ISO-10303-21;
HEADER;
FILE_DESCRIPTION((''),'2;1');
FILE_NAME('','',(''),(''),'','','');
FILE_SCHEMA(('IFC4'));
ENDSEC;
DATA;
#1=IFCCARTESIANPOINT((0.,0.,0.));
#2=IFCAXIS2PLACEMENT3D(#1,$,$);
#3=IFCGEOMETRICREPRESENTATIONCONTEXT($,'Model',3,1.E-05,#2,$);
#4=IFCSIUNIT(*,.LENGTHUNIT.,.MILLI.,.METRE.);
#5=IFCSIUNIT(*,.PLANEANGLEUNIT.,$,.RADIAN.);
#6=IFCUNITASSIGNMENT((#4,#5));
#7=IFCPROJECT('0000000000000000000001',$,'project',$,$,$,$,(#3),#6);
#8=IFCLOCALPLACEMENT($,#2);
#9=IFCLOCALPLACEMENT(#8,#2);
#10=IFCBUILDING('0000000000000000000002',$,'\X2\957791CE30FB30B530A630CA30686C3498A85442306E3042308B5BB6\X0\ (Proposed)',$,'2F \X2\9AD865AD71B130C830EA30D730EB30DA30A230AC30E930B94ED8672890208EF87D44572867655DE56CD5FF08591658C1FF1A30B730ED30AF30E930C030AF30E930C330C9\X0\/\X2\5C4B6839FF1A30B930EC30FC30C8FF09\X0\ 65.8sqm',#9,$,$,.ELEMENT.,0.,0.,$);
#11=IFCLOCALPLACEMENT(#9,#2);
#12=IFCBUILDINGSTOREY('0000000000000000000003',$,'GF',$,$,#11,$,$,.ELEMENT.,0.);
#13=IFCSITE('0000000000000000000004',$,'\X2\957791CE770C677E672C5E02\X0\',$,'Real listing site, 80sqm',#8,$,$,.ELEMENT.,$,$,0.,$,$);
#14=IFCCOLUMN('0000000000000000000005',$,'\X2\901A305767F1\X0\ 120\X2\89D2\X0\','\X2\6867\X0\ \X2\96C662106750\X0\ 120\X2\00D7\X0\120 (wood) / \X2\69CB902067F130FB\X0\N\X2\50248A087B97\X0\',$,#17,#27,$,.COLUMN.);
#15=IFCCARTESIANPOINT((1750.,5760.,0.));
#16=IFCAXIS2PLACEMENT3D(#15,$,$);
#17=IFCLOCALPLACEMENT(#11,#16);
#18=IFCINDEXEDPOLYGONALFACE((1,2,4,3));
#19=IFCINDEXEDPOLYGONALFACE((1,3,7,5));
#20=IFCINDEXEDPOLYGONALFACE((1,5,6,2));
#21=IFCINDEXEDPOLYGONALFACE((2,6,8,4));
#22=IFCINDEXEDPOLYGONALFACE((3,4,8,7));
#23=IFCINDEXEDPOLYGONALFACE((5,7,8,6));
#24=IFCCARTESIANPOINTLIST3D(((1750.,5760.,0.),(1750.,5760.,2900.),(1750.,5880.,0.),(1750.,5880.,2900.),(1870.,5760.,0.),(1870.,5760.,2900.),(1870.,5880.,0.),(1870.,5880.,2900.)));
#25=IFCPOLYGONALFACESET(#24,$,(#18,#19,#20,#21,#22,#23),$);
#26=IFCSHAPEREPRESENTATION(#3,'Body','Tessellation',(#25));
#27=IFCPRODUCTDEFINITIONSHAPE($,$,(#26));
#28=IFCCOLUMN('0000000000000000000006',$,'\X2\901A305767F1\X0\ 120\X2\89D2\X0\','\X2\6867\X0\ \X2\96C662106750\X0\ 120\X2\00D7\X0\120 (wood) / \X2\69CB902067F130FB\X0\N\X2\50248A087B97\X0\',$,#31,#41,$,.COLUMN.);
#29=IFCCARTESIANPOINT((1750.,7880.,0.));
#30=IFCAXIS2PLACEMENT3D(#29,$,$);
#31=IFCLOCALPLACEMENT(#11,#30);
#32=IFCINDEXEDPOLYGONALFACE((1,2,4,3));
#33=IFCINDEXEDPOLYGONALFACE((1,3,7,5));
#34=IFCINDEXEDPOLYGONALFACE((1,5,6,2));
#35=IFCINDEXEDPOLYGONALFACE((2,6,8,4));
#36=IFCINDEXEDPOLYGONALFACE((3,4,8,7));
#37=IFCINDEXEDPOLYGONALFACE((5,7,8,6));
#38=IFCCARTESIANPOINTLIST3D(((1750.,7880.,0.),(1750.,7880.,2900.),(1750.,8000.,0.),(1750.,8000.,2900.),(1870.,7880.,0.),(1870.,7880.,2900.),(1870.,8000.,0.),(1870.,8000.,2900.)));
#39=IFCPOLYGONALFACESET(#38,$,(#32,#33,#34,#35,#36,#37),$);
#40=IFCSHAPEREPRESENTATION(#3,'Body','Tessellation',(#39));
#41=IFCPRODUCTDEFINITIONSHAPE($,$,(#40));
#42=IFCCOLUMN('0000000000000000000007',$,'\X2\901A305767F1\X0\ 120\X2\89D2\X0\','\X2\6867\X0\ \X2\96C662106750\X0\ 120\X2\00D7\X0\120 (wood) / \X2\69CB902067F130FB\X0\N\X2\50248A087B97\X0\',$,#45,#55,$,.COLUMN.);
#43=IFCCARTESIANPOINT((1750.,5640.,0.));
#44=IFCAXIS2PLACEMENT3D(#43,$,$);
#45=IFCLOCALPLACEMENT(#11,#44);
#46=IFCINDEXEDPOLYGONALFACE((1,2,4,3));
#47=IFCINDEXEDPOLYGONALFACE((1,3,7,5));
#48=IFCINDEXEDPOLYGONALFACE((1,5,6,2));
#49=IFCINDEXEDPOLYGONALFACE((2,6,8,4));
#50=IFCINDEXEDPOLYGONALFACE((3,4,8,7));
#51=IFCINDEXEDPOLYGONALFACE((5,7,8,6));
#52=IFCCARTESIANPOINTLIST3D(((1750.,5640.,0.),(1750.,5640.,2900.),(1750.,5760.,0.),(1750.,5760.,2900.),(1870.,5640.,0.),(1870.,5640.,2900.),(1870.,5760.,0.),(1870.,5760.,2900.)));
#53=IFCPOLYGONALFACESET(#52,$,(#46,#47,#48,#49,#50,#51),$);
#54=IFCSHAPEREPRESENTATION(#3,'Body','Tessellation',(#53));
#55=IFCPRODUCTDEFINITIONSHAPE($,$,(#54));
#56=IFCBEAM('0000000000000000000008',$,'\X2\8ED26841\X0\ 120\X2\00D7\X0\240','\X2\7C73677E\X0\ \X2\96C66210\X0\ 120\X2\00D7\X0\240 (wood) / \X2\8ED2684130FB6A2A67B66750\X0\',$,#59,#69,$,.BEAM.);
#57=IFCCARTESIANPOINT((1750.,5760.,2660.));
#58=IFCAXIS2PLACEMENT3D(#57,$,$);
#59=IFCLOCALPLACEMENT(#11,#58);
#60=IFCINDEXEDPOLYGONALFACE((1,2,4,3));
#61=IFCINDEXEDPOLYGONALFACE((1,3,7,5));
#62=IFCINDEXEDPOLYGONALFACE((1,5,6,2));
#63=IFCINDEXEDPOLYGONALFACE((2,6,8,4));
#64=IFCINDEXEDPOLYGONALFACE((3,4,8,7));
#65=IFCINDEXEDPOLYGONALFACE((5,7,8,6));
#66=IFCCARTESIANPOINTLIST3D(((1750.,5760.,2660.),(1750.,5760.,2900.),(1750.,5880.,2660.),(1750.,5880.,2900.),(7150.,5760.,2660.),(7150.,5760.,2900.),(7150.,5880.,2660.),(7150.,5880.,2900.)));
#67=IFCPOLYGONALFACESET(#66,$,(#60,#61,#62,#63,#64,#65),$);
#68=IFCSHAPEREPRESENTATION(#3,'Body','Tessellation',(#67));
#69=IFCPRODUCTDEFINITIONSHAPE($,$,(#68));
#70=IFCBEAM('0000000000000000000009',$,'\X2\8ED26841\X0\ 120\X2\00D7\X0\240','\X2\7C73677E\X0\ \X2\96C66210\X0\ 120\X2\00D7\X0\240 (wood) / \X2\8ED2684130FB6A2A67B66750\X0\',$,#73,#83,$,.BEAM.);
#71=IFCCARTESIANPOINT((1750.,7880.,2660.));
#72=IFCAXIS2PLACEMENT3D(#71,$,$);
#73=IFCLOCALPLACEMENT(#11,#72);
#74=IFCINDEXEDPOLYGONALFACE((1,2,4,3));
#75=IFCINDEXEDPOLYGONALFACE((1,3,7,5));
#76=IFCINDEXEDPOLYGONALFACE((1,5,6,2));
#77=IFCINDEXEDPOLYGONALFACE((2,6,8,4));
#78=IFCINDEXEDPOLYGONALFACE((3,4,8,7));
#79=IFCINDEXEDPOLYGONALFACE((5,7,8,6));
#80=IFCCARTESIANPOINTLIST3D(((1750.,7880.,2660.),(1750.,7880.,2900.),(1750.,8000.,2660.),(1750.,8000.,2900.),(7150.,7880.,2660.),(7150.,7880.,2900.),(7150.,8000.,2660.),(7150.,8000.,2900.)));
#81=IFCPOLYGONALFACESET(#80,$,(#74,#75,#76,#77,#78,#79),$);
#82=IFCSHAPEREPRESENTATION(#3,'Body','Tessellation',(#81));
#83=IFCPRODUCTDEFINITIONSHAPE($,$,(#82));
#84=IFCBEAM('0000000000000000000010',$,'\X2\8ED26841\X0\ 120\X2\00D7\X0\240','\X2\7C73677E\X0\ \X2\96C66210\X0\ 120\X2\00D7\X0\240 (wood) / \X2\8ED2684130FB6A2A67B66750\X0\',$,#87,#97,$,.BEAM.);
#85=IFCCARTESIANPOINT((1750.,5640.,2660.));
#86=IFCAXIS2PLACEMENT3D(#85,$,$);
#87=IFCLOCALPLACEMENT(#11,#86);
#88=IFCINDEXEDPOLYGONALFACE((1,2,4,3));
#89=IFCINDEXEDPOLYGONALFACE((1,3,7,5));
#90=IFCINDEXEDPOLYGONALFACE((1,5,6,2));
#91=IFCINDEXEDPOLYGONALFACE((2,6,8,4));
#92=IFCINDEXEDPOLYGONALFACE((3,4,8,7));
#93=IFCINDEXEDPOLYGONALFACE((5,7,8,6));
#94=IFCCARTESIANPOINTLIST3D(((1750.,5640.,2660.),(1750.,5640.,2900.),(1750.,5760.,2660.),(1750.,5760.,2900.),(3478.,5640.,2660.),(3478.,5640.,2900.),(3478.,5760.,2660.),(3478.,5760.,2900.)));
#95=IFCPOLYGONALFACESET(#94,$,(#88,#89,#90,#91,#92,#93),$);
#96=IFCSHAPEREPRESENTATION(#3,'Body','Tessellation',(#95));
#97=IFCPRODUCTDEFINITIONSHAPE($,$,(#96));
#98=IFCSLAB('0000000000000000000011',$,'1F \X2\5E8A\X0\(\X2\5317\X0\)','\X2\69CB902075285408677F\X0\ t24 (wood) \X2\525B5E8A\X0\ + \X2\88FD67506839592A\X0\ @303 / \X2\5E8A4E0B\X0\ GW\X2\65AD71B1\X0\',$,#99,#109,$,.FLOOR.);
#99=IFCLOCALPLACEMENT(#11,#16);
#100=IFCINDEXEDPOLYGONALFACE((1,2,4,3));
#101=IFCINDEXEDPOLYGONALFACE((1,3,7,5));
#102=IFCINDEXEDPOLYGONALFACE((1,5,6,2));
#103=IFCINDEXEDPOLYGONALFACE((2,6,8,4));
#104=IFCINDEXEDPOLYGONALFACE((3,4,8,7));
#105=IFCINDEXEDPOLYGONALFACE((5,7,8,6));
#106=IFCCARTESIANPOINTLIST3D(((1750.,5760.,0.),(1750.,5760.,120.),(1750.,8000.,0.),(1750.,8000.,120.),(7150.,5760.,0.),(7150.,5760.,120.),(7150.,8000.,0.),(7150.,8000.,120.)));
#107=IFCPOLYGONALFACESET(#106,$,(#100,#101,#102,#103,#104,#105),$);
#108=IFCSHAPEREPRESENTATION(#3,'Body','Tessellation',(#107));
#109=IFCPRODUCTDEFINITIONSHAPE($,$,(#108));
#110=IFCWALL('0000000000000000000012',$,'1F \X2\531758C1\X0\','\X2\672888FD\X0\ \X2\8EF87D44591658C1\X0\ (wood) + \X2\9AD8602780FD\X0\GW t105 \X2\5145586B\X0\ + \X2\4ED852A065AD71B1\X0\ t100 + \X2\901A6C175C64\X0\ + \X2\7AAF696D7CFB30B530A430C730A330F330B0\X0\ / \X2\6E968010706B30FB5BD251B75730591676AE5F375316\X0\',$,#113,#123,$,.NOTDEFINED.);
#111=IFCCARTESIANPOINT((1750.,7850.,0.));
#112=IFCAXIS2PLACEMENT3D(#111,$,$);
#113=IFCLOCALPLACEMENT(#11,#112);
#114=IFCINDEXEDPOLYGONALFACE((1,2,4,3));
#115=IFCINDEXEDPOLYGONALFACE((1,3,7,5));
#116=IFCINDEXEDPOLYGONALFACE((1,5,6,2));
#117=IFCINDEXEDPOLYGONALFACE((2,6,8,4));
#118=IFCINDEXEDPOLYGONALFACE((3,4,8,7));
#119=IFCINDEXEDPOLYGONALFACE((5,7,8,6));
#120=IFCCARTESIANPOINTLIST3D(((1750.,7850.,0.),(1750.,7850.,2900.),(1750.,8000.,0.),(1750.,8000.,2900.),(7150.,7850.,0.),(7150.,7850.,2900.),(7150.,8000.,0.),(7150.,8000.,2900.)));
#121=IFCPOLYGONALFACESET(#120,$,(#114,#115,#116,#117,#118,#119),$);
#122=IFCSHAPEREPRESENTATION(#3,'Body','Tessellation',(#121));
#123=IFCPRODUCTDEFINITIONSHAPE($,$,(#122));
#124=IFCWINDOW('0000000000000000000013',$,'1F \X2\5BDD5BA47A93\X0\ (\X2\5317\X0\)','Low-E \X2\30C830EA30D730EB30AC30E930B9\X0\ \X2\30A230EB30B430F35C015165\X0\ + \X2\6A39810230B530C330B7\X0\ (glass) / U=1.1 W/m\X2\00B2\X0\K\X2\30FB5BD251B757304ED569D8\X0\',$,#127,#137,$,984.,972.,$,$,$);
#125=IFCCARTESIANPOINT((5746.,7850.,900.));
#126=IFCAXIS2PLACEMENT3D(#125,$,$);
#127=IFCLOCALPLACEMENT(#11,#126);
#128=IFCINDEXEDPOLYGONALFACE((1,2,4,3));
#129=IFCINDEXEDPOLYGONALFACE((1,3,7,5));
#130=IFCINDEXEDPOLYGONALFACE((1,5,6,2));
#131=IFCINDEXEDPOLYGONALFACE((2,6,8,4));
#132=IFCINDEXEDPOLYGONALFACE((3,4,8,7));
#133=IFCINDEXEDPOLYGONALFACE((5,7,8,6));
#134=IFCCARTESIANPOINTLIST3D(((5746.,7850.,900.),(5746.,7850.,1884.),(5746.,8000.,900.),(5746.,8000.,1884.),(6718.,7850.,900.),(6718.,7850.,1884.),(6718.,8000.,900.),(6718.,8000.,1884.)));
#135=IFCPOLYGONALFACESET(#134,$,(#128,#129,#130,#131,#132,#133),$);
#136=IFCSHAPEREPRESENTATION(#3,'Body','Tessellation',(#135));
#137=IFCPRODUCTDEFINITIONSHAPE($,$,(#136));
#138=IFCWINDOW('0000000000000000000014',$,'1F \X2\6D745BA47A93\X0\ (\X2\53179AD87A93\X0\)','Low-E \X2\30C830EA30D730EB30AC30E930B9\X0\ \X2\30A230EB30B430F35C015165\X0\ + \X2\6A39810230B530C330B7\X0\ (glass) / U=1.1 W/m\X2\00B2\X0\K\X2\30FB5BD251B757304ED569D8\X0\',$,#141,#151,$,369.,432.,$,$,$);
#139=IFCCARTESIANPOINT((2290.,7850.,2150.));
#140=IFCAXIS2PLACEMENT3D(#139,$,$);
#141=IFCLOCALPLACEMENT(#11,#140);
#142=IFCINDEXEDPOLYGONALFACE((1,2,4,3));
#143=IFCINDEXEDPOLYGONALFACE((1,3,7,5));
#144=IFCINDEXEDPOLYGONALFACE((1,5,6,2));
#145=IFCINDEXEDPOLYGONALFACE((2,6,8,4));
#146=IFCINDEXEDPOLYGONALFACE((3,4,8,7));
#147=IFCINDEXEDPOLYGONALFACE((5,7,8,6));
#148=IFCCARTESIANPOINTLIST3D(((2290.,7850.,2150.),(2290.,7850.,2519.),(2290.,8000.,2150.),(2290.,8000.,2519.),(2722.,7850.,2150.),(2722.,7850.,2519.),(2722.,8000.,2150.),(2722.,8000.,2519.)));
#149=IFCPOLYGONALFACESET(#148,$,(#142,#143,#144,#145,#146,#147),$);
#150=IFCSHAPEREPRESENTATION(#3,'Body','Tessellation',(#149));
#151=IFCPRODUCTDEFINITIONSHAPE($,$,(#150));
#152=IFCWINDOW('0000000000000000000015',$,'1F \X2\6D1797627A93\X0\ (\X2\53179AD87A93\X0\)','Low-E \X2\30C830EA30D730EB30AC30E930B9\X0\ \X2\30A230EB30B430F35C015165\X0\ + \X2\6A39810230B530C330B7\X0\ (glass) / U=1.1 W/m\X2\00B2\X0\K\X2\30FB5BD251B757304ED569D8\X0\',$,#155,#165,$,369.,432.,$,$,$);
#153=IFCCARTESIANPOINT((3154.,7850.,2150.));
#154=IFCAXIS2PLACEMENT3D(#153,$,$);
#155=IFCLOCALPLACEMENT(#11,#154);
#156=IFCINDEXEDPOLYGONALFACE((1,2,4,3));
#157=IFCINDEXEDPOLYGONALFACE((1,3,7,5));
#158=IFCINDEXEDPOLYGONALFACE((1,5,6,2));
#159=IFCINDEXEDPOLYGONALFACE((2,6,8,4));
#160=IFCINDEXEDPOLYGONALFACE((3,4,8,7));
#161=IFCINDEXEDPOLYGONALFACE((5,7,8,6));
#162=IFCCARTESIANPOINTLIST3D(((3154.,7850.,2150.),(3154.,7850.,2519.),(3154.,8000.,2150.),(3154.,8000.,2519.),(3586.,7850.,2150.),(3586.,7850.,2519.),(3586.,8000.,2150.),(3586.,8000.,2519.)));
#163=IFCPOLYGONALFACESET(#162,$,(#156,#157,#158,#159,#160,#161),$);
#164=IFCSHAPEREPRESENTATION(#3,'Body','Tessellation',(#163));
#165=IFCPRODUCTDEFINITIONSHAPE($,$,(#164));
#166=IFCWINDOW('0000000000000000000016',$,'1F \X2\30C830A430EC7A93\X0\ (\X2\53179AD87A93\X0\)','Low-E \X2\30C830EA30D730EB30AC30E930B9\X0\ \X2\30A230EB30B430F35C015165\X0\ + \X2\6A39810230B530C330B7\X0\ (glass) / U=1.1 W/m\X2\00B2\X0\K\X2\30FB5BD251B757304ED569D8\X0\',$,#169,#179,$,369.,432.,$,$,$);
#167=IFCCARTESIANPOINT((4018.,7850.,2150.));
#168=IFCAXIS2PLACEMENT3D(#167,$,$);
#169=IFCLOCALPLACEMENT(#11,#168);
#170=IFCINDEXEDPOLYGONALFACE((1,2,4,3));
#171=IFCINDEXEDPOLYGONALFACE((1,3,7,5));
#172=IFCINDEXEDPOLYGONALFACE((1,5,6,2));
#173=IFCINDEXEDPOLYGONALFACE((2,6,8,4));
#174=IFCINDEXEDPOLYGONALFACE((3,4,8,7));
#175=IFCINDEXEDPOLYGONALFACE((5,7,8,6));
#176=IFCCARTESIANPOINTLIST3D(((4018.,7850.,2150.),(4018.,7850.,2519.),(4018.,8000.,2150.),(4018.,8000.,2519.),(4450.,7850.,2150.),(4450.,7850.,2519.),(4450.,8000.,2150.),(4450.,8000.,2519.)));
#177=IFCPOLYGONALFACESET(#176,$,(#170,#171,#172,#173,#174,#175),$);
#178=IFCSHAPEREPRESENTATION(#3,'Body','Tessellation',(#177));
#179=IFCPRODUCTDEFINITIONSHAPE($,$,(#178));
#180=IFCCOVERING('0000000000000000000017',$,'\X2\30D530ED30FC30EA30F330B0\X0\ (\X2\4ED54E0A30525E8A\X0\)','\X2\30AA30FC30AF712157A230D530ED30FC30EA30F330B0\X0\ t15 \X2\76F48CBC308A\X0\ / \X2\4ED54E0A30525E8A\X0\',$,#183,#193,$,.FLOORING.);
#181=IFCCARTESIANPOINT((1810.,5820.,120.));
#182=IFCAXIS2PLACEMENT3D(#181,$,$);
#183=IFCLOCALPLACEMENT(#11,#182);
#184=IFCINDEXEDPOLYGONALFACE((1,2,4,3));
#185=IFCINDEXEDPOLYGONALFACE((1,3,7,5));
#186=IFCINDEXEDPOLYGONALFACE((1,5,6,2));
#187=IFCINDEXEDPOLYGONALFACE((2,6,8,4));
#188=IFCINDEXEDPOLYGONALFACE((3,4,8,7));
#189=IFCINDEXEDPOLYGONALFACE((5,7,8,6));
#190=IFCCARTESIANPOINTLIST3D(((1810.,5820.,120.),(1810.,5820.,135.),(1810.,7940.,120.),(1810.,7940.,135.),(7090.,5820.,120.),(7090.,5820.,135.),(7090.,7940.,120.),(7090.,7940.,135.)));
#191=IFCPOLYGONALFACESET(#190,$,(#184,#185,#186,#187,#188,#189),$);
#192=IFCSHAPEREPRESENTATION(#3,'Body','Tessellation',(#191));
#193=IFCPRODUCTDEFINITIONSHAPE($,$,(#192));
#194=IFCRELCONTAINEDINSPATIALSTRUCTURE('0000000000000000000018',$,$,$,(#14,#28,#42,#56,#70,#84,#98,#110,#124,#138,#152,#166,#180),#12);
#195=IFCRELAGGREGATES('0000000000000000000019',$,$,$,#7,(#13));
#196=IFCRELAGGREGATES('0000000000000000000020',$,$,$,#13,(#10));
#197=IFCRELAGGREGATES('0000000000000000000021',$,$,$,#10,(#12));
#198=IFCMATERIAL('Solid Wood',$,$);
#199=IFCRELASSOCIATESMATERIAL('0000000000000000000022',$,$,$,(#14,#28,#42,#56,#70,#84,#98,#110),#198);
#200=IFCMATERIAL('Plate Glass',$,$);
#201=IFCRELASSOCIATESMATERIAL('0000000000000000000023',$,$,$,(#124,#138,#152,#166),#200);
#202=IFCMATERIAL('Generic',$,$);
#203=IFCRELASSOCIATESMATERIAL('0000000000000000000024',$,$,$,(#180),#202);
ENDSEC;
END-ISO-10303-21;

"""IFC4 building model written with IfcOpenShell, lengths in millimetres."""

from ifc_helpers import new_model, si_unit, frame, frame_2d, origin, place, context, project, spatial, rectangle, extrude, material, element, fill, save


model = new_model("IFC4")

# Units and contexts
model_context = context("Model", 3, precision=1e-05, world=origin())
ifc_project = project(units=[si_unit("LENGTHUNIT", "METRE", prefix="MILLI"), si_unit("PLANEANGLEUNIT", "RADIAN")], contexts=[model_context])

# Site, building, storey
site_placement = place(None, origin())
site = spatial("IfcSite", under=ifc_project, at=site_placement, Name="長野県松本市", ObjectType="Real listing site, 80sqm", CompositionType="ELEMENT", RefElevation=0.0)
building_placement = place(site_placement, origin())
building = spatial("IfcBuilding", under=site, at=building_placement, Name="長野・サウナと水風呂のある家 (Proposed)", ObjectType="2F 高断熱トリプルペアガラス付木造軸組在来工法（外壁：シロクラダクラッド/屋根：スレート） 65.8sqm", CompositionType="ELEMENT", ElevationOfRefHeight=0.0, ElevationOfTerrain=0.0)
storey_placement = place(building_placement, origin())
storey = spatial("IfcBuildingStorey", under=building, at=storey_placement, Name="GF", CompositionType="ELEMENT", Elevation=0.0)

# Columns
ifc_material_1 = material(Name="Solid Wood")
column_1_placement = place(storey_placement, frame((1750.0, 5760.0, 0.0)))
element("IfcColumn", 1, at=column_1_placement, inside=storey, material=ifc_material_1, Name="通し柱 120角", Description="桧 集成材 120×120 (wood) / 構造柱・N値計算", PredefinedType="COLUMN", context=model_context, shape_type="SweptSolid", body=[
    extrude(rectangle(XDim=120.0, YDim=120.0, at=frame_2d((60.0, 60.0))), frame((1750.0, 5760.0, 0.0)), (0.0, 0.0, 1.0), 2900.0),
])
column_2_placement = place(storey_placement, frame((1750.0, 7880.0, 0.0)))
element("IfcColumn", 2, at=column_2_placement, inside=storey, material=ifc_material_1, Name="通し柱 120角", Description="桧 集成材 120×120 (wood) / 構造柱・N値計算", PredefinedType="COLUMN", context=model_context, shape_type="SweptSolid", body=[
    extrude(rectangle(XDim=120.0, YDim=120.0, at=frame_2d((60.0, 60.0))), frame((1750.0, 7880.0, 0.0)), (0.0, 0.0, 1.0), 2900.0),
])
column_3_placement = place(storey_placement, frame((1750.0, 5640.0, 0.0)))
element("IfcColumn", 3, at=column_3_placement, inside=storey, material=ifc_material_1, Name="通し柱 120角", Description="桧 集成材 120×120 (wood) / 構造柱・N値計算", PredefinedType="COLUMN", context=model_context, shape_type="SweptSolid", body=[
    extrude(rectangle(XDim=120.0, YDim=120.0, at=frame_2d((60.0, 60.0))), frame((1750.0, 5640.0, 0.0)), (0.0, 0.0, 1.0), 2900.0),
])

# Beams
beam_1_placement = place(storey_placement, frame((1750.0, 5760.0, 2660.0)))
element("IfcBeam", 4, at=beam_1_placement, inside=storey, material=ifc_material_1, Name="軒桁 120×240", Description="米松 集成 120×240 (wood) / 軒桁・横架材", PredefinedType="BEAM", context=model_context, shape_type="SweptSolid", body=[
    extrude(rectangle(XDim=5400.0, YDim=120.0, at=frame_2d((2700.0, 60.0))), frame((1750.0, 5760.0, 2660.0)), (0.0, 0.0, 1.0), 240.0),
])
beam_2_placement = place(storey_placement, frame((1750.0, 7880.0, 2660.0)))
element("IfcBeam", 5, at=beam_2_placement, inside=storey, material=ifc_material_1, Name="軒桁 120×240", Description="米松 集成 120×240 (wood) / 軒桁・横架材", PredefinedType="BEAM", context=model_context, shape_type="SweptSolid", body=[
    extrude(rectangle(XDim=5400.0, YDim=120.0, at=frame_2d((2700.0, 60.0))), frame((1750.0, 7880.0, 2660.0)), (0.0, 0.0, 1.0), 240.0),
])
beam_3_placement = place(storey_placement, frame((1750.0, 5640.0, 2660.0)))
element("IfcBeam", 6, at=beam_3_placement, inside=storey, material=ifc_material_1, Name="軒桁 120×240", Description="米松 集成 120×240 (wood) / 軒桁・横架材", PredefinedType="BEAM", context=model_context, shape_type="SweptSolid", body=[
    extrude(rectangle(XDim=1728.0, YDim=120.0, at=frame_2d((864.0, 60.0))), frame((1750.0, 5640.0, 2660.0)), (0.0, 0.0, 1.0), 240.0),
])

# Slab
slab_placement = place(storey_placement, frame((1750.0, 5760.0, 0.0)))
element("IfcSlab", 7, at=slab_placement, inside=storey, material=ifc_material_1, Name="1F 床(北)", Description="構造用合板 t24 (wood) 剛床 + 製材根太 @303 / 床下 GW断熱", PredefinedType="FLOOR", context=model_context, shape_type="SweptSolid", body=[
    extrude(rectangle(XDim=5400.0, YDim=2240.0, at=frame_2d((2700.0, 1120.0))), frame((1750.0, 5760.0, 0.0)), (0.0, 0.0, 1.0), 120.0),
])

# Wall, openings, windows
wall_1_placement = place(storey_placement, frame((1750.0, 7850.0, 0.0)))
wall_1 = element("IfcWall", 8, at=wall_1_placement, inside=storey, material=ifc_material_1, Name="1F 北壁", Description="木製 軸組外壁 (wood) + 高性能GW t105 充填 + 付加断熱 t100 + 通気層 + 窯業系サイディング / 準耐火・寒冷地外皮強化", PredefinedType="NOTDEFINED", context=model_context, shape_type="SweptSolid", body=[
    extrude(rectangle(XDim=5400.0, YDim=150.0, at=frame_2d((2700.0, 75.0))), frame((1750.0, 7850.0, 0.0)), (0.0, 0.0, 1.0), 2900.0),
])
opening_1_placement = place(storey_placement, frame((5746.0, 7850.0, 900.0)))
opening_1 = element("IfcOpeningElement", 9, at=opening_1_placement, cuts=wall_1, PredefinedType="NOTDEFINED", context=model_context, shape_type="SweptSolid", body=[
    extrude(rectangle(XDim=972.0, YDim=150.0, at=frame_2d((486.0, 75.0))), frame((5746.0, 7850.0, 900.0)), (0.0, 0.0, 1.0), 984.0),
])
opening_2_placement = place(storey_placement, frame((2290.0, 7850.0, 2150.0)))
opening_2 = element("IfcOpeningElement", 10, at=opening_2_placement, cuts=wall_1, PredefinedType="NOTDEFINED", context=model_context, shape_type="SweptSolid", body=[
    extrude(rectangle(XDim=432.0, YDim=150.0, at=frame_2d((216.0, 75.0))), frame((2290.0, 7850.0, 2150.0)), (0.0, 0.0, 1.0), 369.0),
])
opening_3_placement = place(storey_placement, frame((3154.0, 7850.0, 2150.0)))
opening_3 = element("IfcOpeningElement", 11, at=opening_3_placement, cuts=wall_1, PredefinedType="NOTDEFINED", context=model_context, shape_type="SweptSolid", body=[
    extrude(rectangle(XDim=432.0, YDim=150.0, at=frame_2d((216.0, 75.0))), frame((3154.0, 7850.0, 2150.0)), (0.0, 0.0, 1.0), 369.0),
])
opening_4_placement = place(storey_placement, frame((4018.0, 7850.0, 2150.0)))
opening_4 = element("IfcOpeningElement", 12, at=opening_4_placement, cuts=wall_1, PredefinedType="NOTDEFINED", context=model_context, shape_type="SweptSolid", body=[
    extrude(rectangle(XDim=432.0, YDim=150.0, at=frame_2d((216.0, 75.0))), frame((4018.0, 7850.0, 2150.0)), (0.0, 0.0, 1.0), 369.0),
])
ifc_material_2 = material(Name="Plate Glass")
window_1_placement = place(storey_placement, frame((5746.0, 7850.0, 900.0)))
window_1 = element("IfcWindow", 13, at=window_1_placement, inside=storey, material=ifc_material_2, Name="1F 寝室窓 (北)", Description="Low-E トリプルガラス アルゴン封入 + 樹脂サッシ (glass) / U=1.1 W/m²K・寒冷地仕様", OverallHeight=984.0, OverallWidth=972.0, context=model_context, shape_type="SweptSolid", body=[
    extrude(rectangle(XDim=972.0, YDim=150.0, at=frame_2d((486.0, 75.0))), frame((5746.0, 7850.0, 900.0)), (0.0, 0.0, 1.0), 984.0),
])
fill(opening_1, window_1)
window_2_placement = place(storey_placement, frame((2290.0, 7850.0, 2150.0)))
window_2 = element("IfcWindow", 14, at=window_2_placement, inside=storey, material=ifc_material_2, Name="1F 浴室窓 (北高窓)", Description="Low-E トリプルガラス アルゴン封入 + 樹脂サッシ (glass) / U=1.1 W/m²K・寒冷地仕様", OverallHeight=369.0, OverallWidth=432.0, context=model_context, shape_type="SweptSolid", body=[
    extrude(rectangle(XDim=432.0, YDim=150.0, at=frame_2d((216.0, 75.0))), frame((2290.0, 7850.0, 2150.0)), (0.0, 0.0, 1.0), 369.0),
])
fill(opening_2, window_2)
window_3_placement = place(storey_placement, frame((3154.0, 7850.0, 2150.0)))
window_3 = element("IfcWindow", 15, at=window_3_placement, inside=storey, material=ifc_material_2, Name="1F 洗面窓 (北高窓)", Description="Low-E トリプルガラス アルゴン封入 + 樹脂サッシ (glass) / U=1.1 W/m²K・寒冷地仕様", OverallHeight=369.0, OverallWidth=432.0, context=model_context, shape_type="SweptSolid", body=[
    extrude(rectangle(XDim=432.0, YDim=150.0, at=frame_2d((216.0, 75.0))), frame((3154.0, 7850.0, 2150.0)), (0.0, 0.0, 1.0), 369.0),
])
fill(opening_3, window_3)
window_4_placement = place(storey_placement, frame((4018.0, 7850.0, 2150.0)))
window_4 = element("IfcWindow", 16, at=window_4_placement, inside=storey, material=ifc_material_2, Name="1F トイレ窓 (北高窓)", Description="Low-E トリプルガラス アルゴン封入 + 樹脂サッシ (glass) / U=1.1 W/m²K・寒冷地仕様", OverallHeight=369.0, OverallWidth=432.0, context=model_context, shape_type="SweptSolid", body=[
    extrude(rectangle(XDim=432.0, YDim=150.0, at=frame_2d((216.0, 75.0))), frame((4018.0, 7850.0, 2150.0)), (0.0, 0.0, 1.0), 369.0),
])
fill(opening_4, window_4)

# Covering
ifc_material_3 = material(Name="Generic")
covering_1_placement = place(storey_placement, frame((1810.0, 5820.0, 120.0)))
element("IfcCovering", 17, at=covering_1_placement, inside=storey, material=ifc_material_3, Name="フローリング (仕上げ床)", Description="オーク無垢フローリング t15 直貼り / 仕上げ床", PredefinedType="FLOORING", context=model_context, shape_type="SweptSolid", body=[
    extrude(rectangle(XDim=5280.0, YDim=2120.0, at=frame_2d((2640.0, 1060.0))), frame((1810.0, 5820.0, 120.0)), (0.0, 0.0, 1.0), 15.0),
])

save(model, "model.ifc")
